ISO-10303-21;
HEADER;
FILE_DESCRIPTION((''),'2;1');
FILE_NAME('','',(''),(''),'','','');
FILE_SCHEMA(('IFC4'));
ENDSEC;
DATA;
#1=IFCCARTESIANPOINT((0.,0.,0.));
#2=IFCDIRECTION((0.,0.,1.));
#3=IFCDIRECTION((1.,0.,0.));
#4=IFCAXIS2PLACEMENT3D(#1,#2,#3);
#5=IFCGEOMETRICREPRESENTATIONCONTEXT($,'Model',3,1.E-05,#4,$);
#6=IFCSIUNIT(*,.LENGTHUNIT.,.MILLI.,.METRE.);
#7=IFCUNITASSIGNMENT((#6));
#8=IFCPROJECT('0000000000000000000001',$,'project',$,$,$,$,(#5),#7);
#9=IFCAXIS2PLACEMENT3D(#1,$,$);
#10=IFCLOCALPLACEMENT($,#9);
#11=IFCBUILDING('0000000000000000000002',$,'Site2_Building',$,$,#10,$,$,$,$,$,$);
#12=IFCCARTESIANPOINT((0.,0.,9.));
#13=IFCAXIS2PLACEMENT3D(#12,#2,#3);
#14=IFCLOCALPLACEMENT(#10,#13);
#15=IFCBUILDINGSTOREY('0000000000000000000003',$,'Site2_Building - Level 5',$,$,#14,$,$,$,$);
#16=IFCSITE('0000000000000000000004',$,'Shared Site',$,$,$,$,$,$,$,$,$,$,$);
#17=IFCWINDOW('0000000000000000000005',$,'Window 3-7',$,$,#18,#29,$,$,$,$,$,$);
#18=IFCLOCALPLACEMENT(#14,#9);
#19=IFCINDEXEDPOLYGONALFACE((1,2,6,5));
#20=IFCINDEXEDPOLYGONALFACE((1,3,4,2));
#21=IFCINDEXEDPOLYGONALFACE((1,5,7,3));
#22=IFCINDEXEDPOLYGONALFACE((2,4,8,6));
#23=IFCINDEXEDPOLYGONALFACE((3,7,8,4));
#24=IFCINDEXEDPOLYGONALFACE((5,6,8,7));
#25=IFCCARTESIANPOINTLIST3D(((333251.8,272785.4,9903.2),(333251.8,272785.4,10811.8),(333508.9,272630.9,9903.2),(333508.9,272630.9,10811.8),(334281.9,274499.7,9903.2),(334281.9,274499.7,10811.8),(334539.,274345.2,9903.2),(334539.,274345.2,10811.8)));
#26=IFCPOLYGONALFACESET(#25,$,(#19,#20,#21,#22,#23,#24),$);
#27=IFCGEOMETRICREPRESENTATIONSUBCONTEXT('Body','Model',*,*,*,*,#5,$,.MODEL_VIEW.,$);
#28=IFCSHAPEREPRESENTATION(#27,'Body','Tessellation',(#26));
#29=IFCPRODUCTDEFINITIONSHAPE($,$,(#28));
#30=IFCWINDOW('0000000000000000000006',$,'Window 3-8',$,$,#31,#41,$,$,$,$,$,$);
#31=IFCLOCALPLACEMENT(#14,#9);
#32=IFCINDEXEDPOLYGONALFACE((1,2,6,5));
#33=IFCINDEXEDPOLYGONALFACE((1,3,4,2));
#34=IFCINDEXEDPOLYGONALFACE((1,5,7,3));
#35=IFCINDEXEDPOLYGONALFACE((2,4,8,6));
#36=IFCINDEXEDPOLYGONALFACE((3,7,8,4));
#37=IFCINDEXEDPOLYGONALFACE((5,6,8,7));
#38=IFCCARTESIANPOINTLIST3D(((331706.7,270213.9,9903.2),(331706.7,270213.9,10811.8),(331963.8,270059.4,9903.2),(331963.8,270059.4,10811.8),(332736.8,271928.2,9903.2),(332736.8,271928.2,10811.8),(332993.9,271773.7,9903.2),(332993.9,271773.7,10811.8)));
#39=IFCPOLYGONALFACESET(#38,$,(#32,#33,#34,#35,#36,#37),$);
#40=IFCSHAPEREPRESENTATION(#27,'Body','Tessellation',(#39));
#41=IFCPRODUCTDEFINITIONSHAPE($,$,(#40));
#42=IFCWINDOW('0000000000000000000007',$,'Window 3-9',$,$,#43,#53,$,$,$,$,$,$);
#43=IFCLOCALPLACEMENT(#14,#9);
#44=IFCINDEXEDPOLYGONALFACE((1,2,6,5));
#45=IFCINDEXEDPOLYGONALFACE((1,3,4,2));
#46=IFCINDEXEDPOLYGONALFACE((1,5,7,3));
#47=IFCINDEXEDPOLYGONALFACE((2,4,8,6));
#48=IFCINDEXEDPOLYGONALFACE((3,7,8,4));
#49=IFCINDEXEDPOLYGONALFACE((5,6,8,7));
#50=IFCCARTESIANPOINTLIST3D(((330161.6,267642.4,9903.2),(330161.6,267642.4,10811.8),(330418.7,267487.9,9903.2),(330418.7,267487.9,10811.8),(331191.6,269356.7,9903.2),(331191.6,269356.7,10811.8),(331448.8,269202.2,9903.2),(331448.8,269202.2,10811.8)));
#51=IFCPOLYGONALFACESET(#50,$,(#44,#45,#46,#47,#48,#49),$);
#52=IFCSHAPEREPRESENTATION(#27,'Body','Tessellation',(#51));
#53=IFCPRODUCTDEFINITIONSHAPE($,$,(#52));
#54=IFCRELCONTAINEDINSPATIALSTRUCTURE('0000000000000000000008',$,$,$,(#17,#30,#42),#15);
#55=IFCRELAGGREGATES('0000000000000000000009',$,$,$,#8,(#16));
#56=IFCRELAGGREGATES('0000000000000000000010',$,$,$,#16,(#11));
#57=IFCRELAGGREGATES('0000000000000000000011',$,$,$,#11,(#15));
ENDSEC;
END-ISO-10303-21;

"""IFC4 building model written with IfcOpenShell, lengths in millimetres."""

from ifc_helpers import new_model, si_unit, frame, origin, origin_with_axes, place, context, subcontext, project, spatial, indexed_curve, outline, extrude, element, save


model = new_model("IFC4")

# Units and contexts
model_context = context("Model", 3, precision=1e-05, world=origin_with_axes())
body_context = subcontext(model_context, "Body", "Model", "MODEL_VIEW")
ifc_project = project(units=[si_unit("LENGTHUNIT", "METRE", prefix="MILLI")], contexts=[model_context])

# Site, building, storey
site = spatial("IfcSite", under=ifc_project, Name="Shared Site")
building_placement = place(None, origin())
building = spatial("IfcBuilding", under=site, at=building_placement, Name="Site2_Building")
storey_placement = place(building_placement, frame((0.0, 0.0, 9.0), z_axis=(0.0, 0.0, 1.0), x_axis=(1.0, 0.0, 0.0)))
storey = spatial("IfcBuildingStorey", under=building, at=storey_placement, Name="Site2_Building - Level 5")

# Windows
for number, where, z_axis, x_axis, name in (
    (1, (334281.9, 274499.7, 9903.2), (0.0, 0.0, 1.0), (-0.515038, -0.857167, 0.0), "Window 3-7"),
    (2, (332736.8, 271928.2, 9903.2), (0.0, 0.0, 1.0), (-0.515038, -0.857167, 0.0), "Window 3-8"),
    (3, (331191.6, 269356.7, 9903.2), (0.0, 0.0, 1.0), (-0.515038, -0.857167, 0.0), "Window 3-9"),
):
    element("IfcWindow", number, at=place(storey_placement, frame(where, z_axis=z_axis, x_axis=x_axis)), inside=storey, Name=name, context=body_context, shape_type="SweptSolid", body=[
        extrude(outline(indexed_curve([(0.0, 0.0), (0.0, 300.0), (2000.0, 300.0), (2000.0, 0.0), (0.0, 0.0)], self_intersect=False)), origin_with_axes(), (0.0, 0.0, 1.0), 908.6),
    ])

save(model, "model.ifc")
